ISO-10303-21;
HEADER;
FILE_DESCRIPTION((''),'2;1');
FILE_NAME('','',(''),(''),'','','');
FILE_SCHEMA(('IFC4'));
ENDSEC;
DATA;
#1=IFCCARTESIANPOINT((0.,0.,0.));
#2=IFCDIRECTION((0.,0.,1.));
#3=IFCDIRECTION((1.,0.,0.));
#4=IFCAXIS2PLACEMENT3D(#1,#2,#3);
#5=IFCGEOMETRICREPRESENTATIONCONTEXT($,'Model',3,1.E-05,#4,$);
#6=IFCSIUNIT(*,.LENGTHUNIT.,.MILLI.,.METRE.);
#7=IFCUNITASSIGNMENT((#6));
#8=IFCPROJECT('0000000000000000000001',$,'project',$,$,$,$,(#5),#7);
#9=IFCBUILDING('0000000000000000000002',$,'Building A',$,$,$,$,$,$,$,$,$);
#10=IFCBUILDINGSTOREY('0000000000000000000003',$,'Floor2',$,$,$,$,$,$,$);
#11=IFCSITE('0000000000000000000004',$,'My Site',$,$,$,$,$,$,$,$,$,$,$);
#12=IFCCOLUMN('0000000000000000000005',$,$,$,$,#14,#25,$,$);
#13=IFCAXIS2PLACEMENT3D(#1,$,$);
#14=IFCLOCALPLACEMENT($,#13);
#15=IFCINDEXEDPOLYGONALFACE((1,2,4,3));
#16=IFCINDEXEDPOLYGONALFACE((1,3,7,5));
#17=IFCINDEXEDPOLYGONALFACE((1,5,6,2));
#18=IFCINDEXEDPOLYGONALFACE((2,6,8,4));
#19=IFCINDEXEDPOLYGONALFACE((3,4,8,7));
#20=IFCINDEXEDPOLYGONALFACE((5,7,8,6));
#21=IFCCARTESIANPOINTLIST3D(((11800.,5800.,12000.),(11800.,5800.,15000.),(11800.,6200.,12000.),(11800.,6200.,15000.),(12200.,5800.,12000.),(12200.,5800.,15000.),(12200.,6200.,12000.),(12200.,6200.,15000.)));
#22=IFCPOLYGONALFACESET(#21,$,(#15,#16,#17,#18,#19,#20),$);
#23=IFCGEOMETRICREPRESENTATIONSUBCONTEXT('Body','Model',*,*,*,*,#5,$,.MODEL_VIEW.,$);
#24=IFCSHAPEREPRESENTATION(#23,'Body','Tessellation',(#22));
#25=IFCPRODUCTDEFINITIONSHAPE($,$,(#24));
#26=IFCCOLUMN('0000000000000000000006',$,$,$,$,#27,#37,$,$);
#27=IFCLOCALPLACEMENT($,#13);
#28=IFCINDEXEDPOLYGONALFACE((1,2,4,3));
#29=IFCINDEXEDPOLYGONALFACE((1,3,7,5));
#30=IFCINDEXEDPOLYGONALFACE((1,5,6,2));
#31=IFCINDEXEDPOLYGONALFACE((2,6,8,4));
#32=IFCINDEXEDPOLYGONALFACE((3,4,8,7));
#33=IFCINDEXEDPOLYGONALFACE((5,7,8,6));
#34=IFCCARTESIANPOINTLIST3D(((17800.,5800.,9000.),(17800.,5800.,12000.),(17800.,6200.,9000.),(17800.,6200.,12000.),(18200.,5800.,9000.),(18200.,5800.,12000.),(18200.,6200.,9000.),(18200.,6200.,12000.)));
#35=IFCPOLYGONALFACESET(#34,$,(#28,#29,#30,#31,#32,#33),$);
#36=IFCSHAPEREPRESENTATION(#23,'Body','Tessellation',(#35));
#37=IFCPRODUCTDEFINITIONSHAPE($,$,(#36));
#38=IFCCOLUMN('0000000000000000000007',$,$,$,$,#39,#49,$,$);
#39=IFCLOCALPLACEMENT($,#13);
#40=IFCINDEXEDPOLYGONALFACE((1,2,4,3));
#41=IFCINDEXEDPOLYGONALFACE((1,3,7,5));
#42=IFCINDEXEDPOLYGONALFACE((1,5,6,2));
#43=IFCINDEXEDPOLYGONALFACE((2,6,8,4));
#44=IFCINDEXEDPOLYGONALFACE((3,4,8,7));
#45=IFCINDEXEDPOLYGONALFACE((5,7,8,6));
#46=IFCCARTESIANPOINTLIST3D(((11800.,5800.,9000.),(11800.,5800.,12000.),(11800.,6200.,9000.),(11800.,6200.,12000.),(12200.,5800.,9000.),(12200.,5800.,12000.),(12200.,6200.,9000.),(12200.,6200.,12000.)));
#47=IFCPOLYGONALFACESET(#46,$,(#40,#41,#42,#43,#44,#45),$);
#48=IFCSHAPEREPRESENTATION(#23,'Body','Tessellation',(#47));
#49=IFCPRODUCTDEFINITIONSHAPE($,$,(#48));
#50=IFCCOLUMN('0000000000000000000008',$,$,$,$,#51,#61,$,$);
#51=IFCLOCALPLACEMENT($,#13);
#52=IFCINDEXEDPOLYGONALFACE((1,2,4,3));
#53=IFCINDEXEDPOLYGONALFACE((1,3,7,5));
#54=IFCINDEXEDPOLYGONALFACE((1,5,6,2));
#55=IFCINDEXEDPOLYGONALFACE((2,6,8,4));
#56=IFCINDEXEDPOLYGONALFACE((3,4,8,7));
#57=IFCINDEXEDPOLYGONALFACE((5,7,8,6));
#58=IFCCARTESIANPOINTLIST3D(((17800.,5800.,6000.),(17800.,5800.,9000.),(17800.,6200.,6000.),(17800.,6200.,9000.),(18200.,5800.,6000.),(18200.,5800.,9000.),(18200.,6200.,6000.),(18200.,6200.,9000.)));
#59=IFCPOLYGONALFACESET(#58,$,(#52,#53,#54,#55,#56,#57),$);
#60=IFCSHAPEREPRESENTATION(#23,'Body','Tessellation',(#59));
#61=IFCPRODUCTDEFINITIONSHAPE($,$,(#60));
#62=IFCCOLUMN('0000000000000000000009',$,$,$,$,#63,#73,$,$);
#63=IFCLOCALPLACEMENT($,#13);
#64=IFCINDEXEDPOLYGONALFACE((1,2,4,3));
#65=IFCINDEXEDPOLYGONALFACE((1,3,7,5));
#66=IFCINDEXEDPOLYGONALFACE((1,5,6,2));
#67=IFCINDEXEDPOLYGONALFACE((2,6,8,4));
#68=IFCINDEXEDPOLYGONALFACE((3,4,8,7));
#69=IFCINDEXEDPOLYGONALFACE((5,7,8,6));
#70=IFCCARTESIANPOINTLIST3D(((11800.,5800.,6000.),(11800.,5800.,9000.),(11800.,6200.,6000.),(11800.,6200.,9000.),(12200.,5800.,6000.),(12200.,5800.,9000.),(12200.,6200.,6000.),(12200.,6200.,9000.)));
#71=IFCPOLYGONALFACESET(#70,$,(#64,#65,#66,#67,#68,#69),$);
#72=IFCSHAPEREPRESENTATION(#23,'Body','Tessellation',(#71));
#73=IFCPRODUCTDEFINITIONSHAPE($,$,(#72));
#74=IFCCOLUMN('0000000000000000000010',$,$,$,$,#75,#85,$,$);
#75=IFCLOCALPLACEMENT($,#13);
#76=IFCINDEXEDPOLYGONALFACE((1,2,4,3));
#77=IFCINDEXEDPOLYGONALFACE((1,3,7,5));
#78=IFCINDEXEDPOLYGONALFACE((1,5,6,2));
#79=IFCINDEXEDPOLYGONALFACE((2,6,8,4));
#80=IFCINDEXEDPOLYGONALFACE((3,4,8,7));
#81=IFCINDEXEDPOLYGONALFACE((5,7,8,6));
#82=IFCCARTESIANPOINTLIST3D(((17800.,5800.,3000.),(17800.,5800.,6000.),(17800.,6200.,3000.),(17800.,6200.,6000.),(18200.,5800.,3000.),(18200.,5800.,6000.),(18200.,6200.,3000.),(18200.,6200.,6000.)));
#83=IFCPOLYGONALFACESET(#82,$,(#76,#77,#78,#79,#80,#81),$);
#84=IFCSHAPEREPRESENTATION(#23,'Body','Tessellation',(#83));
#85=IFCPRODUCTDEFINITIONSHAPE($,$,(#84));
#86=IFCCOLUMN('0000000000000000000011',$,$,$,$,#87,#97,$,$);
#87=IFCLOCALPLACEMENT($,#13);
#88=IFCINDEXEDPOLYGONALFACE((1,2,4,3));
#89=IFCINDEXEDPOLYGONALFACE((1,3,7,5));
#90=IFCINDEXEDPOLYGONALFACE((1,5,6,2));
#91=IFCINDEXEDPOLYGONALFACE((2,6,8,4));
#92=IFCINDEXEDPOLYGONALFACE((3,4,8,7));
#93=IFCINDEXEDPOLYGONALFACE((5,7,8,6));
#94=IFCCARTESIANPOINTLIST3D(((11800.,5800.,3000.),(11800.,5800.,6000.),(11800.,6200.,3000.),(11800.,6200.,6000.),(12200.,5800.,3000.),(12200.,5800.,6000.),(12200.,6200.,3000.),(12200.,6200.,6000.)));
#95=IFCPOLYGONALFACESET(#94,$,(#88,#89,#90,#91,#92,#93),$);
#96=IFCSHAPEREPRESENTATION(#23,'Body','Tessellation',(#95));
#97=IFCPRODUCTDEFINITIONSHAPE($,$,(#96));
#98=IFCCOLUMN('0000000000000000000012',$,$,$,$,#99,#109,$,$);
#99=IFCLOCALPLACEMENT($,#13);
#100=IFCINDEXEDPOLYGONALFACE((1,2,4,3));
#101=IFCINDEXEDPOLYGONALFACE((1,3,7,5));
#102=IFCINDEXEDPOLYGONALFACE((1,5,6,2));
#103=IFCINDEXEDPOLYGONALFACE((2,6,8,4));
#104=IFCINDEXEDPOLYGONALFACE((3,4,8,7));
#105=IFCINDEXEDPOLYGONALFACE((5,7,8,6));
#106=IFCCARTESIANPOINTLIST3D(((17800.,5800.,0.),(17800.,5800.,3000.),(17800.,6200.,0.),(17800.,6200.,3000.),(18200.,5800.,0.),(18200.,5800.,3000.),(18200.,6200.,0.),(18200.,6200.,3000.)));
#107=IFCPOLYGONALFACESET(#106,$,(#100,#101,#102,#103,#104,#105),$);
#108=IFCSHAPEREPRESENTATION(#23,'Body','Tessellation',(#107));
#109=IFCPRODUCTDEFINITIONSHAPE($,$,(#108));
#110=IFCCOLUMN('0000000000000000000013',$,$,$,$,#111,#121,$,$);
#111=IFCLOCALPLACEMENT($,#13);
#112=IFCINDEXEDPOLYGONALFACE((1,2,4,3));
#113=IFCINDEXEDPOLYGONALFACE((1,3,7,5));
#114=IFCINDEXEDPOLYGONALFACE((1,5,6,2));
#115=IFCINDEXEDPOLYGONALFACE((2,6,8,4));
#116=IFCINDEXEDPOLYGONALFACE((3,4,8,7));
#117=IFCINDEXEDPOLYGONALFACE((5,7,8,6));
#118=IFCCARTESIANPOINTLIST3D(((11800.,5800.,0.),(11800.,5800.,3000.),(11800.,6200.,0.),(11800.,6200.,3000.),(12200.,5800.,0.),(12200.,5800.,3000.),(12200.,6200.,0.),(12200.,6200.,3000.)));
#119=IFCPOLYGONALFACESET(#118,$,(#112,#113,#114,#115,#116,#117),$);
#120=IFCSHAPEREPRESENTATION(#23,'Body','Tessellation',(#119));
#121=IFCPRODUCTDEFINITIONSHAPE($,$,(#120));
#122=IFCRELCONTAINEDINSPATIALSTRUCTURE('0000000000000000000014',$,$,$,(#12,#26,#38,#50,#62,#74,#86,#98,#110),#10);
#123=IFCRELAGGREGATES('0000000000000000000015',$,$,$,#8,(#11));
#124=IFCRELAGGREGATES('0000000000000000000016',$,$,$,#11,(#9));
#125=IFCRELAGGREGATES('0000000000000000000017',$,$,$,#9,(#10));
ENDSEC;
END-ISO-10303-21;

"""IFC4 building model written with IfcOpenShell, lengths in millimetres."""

from ifc_helpers import new_model, si_unit, frame, origin_with_axes, place, context, subcontext, project, spatial, line, indexed_curve, outline, extrude, element, save


model = new_model("IFC4")

# Units and contexts
model_context = context("Model", 3, precision=1e-05, world=origin_with_axes())
body_context = subcontext(model_context, "Body", "Model", "MODEL_VIEW")
ifc_project = project(units=[si_unit("LENGTHUNIT", "METRE", prefix="MILLI")], contexts=[model_context])

# Site, building, storey
site = spatial("IfcSite", under=ifc_project, Name="My Site")
building = spatial("IfcBuilding", under=site, Name="Building A")
storey = spatial("IfcBuildingStorey", under=building, Name="Floor2")

# Columns
for number, where, z_axis, x_axis in (
    (1, (12000.0, 6000.0, 12000.0), (0.0, 0.0, 1.0), (1.0, 0.0, 0.0)),
    (2, (18000.0, 6000.0, 9000.0), (0.0, 0.0, 1.0), (1.0, 0.0, 0.0)),
    (3, (12000.0, 6000.0, 9000.0), (0.0, 0.0, 1.0), (1.0, 0.0, 0.0)),
    (4, (18000.0, 6000.0, 6000.0), (0.0, 0.0, 1.0), (1.0, 0.0, 0.0)),
    (5, (12000.0, 6000.0, 6000.0), (0.0, 0.0, 1.0), (1.0, 0.0, 0.0)),
    (6, (18000.0, 6000.0, 3000.0), (0.0, 0.0, 1.0), (1.0, 0.0, 0.0)),
    (7, (12000.0, 6000.0, 3000.0), (0.0, 0.0, 1.0), (1.0, 0.0, 0.0)),
    (8, (18000.0, 6000.0, 0.0), (0.0, 0.0, 1.0), (1.0, 0.0, 0.0)),
    (9, (12000.0, 6000.0, 0.0), (0.0, 0.0, 1.0), (1.0, 0.0, 0.0)),
):
    element("IfcColumn", number, at=place(None, frame(where, z_axis=z_axis, x_axis=x_axis)), inside=storey, context=body_context, shape_type="SweptSolid", body=[
        extrude(outline(indexed_curve([(-200.0, -200.0), (200.0, -200.0), (200.0, 200.0), (-200.0, 200.0)], segments=[line(1, 2, 3, 4, 1)])), origin_with_axes(), (0.0, 0.0, 1.0), 3000.0),
    ])

save(model, "model.ifc")
